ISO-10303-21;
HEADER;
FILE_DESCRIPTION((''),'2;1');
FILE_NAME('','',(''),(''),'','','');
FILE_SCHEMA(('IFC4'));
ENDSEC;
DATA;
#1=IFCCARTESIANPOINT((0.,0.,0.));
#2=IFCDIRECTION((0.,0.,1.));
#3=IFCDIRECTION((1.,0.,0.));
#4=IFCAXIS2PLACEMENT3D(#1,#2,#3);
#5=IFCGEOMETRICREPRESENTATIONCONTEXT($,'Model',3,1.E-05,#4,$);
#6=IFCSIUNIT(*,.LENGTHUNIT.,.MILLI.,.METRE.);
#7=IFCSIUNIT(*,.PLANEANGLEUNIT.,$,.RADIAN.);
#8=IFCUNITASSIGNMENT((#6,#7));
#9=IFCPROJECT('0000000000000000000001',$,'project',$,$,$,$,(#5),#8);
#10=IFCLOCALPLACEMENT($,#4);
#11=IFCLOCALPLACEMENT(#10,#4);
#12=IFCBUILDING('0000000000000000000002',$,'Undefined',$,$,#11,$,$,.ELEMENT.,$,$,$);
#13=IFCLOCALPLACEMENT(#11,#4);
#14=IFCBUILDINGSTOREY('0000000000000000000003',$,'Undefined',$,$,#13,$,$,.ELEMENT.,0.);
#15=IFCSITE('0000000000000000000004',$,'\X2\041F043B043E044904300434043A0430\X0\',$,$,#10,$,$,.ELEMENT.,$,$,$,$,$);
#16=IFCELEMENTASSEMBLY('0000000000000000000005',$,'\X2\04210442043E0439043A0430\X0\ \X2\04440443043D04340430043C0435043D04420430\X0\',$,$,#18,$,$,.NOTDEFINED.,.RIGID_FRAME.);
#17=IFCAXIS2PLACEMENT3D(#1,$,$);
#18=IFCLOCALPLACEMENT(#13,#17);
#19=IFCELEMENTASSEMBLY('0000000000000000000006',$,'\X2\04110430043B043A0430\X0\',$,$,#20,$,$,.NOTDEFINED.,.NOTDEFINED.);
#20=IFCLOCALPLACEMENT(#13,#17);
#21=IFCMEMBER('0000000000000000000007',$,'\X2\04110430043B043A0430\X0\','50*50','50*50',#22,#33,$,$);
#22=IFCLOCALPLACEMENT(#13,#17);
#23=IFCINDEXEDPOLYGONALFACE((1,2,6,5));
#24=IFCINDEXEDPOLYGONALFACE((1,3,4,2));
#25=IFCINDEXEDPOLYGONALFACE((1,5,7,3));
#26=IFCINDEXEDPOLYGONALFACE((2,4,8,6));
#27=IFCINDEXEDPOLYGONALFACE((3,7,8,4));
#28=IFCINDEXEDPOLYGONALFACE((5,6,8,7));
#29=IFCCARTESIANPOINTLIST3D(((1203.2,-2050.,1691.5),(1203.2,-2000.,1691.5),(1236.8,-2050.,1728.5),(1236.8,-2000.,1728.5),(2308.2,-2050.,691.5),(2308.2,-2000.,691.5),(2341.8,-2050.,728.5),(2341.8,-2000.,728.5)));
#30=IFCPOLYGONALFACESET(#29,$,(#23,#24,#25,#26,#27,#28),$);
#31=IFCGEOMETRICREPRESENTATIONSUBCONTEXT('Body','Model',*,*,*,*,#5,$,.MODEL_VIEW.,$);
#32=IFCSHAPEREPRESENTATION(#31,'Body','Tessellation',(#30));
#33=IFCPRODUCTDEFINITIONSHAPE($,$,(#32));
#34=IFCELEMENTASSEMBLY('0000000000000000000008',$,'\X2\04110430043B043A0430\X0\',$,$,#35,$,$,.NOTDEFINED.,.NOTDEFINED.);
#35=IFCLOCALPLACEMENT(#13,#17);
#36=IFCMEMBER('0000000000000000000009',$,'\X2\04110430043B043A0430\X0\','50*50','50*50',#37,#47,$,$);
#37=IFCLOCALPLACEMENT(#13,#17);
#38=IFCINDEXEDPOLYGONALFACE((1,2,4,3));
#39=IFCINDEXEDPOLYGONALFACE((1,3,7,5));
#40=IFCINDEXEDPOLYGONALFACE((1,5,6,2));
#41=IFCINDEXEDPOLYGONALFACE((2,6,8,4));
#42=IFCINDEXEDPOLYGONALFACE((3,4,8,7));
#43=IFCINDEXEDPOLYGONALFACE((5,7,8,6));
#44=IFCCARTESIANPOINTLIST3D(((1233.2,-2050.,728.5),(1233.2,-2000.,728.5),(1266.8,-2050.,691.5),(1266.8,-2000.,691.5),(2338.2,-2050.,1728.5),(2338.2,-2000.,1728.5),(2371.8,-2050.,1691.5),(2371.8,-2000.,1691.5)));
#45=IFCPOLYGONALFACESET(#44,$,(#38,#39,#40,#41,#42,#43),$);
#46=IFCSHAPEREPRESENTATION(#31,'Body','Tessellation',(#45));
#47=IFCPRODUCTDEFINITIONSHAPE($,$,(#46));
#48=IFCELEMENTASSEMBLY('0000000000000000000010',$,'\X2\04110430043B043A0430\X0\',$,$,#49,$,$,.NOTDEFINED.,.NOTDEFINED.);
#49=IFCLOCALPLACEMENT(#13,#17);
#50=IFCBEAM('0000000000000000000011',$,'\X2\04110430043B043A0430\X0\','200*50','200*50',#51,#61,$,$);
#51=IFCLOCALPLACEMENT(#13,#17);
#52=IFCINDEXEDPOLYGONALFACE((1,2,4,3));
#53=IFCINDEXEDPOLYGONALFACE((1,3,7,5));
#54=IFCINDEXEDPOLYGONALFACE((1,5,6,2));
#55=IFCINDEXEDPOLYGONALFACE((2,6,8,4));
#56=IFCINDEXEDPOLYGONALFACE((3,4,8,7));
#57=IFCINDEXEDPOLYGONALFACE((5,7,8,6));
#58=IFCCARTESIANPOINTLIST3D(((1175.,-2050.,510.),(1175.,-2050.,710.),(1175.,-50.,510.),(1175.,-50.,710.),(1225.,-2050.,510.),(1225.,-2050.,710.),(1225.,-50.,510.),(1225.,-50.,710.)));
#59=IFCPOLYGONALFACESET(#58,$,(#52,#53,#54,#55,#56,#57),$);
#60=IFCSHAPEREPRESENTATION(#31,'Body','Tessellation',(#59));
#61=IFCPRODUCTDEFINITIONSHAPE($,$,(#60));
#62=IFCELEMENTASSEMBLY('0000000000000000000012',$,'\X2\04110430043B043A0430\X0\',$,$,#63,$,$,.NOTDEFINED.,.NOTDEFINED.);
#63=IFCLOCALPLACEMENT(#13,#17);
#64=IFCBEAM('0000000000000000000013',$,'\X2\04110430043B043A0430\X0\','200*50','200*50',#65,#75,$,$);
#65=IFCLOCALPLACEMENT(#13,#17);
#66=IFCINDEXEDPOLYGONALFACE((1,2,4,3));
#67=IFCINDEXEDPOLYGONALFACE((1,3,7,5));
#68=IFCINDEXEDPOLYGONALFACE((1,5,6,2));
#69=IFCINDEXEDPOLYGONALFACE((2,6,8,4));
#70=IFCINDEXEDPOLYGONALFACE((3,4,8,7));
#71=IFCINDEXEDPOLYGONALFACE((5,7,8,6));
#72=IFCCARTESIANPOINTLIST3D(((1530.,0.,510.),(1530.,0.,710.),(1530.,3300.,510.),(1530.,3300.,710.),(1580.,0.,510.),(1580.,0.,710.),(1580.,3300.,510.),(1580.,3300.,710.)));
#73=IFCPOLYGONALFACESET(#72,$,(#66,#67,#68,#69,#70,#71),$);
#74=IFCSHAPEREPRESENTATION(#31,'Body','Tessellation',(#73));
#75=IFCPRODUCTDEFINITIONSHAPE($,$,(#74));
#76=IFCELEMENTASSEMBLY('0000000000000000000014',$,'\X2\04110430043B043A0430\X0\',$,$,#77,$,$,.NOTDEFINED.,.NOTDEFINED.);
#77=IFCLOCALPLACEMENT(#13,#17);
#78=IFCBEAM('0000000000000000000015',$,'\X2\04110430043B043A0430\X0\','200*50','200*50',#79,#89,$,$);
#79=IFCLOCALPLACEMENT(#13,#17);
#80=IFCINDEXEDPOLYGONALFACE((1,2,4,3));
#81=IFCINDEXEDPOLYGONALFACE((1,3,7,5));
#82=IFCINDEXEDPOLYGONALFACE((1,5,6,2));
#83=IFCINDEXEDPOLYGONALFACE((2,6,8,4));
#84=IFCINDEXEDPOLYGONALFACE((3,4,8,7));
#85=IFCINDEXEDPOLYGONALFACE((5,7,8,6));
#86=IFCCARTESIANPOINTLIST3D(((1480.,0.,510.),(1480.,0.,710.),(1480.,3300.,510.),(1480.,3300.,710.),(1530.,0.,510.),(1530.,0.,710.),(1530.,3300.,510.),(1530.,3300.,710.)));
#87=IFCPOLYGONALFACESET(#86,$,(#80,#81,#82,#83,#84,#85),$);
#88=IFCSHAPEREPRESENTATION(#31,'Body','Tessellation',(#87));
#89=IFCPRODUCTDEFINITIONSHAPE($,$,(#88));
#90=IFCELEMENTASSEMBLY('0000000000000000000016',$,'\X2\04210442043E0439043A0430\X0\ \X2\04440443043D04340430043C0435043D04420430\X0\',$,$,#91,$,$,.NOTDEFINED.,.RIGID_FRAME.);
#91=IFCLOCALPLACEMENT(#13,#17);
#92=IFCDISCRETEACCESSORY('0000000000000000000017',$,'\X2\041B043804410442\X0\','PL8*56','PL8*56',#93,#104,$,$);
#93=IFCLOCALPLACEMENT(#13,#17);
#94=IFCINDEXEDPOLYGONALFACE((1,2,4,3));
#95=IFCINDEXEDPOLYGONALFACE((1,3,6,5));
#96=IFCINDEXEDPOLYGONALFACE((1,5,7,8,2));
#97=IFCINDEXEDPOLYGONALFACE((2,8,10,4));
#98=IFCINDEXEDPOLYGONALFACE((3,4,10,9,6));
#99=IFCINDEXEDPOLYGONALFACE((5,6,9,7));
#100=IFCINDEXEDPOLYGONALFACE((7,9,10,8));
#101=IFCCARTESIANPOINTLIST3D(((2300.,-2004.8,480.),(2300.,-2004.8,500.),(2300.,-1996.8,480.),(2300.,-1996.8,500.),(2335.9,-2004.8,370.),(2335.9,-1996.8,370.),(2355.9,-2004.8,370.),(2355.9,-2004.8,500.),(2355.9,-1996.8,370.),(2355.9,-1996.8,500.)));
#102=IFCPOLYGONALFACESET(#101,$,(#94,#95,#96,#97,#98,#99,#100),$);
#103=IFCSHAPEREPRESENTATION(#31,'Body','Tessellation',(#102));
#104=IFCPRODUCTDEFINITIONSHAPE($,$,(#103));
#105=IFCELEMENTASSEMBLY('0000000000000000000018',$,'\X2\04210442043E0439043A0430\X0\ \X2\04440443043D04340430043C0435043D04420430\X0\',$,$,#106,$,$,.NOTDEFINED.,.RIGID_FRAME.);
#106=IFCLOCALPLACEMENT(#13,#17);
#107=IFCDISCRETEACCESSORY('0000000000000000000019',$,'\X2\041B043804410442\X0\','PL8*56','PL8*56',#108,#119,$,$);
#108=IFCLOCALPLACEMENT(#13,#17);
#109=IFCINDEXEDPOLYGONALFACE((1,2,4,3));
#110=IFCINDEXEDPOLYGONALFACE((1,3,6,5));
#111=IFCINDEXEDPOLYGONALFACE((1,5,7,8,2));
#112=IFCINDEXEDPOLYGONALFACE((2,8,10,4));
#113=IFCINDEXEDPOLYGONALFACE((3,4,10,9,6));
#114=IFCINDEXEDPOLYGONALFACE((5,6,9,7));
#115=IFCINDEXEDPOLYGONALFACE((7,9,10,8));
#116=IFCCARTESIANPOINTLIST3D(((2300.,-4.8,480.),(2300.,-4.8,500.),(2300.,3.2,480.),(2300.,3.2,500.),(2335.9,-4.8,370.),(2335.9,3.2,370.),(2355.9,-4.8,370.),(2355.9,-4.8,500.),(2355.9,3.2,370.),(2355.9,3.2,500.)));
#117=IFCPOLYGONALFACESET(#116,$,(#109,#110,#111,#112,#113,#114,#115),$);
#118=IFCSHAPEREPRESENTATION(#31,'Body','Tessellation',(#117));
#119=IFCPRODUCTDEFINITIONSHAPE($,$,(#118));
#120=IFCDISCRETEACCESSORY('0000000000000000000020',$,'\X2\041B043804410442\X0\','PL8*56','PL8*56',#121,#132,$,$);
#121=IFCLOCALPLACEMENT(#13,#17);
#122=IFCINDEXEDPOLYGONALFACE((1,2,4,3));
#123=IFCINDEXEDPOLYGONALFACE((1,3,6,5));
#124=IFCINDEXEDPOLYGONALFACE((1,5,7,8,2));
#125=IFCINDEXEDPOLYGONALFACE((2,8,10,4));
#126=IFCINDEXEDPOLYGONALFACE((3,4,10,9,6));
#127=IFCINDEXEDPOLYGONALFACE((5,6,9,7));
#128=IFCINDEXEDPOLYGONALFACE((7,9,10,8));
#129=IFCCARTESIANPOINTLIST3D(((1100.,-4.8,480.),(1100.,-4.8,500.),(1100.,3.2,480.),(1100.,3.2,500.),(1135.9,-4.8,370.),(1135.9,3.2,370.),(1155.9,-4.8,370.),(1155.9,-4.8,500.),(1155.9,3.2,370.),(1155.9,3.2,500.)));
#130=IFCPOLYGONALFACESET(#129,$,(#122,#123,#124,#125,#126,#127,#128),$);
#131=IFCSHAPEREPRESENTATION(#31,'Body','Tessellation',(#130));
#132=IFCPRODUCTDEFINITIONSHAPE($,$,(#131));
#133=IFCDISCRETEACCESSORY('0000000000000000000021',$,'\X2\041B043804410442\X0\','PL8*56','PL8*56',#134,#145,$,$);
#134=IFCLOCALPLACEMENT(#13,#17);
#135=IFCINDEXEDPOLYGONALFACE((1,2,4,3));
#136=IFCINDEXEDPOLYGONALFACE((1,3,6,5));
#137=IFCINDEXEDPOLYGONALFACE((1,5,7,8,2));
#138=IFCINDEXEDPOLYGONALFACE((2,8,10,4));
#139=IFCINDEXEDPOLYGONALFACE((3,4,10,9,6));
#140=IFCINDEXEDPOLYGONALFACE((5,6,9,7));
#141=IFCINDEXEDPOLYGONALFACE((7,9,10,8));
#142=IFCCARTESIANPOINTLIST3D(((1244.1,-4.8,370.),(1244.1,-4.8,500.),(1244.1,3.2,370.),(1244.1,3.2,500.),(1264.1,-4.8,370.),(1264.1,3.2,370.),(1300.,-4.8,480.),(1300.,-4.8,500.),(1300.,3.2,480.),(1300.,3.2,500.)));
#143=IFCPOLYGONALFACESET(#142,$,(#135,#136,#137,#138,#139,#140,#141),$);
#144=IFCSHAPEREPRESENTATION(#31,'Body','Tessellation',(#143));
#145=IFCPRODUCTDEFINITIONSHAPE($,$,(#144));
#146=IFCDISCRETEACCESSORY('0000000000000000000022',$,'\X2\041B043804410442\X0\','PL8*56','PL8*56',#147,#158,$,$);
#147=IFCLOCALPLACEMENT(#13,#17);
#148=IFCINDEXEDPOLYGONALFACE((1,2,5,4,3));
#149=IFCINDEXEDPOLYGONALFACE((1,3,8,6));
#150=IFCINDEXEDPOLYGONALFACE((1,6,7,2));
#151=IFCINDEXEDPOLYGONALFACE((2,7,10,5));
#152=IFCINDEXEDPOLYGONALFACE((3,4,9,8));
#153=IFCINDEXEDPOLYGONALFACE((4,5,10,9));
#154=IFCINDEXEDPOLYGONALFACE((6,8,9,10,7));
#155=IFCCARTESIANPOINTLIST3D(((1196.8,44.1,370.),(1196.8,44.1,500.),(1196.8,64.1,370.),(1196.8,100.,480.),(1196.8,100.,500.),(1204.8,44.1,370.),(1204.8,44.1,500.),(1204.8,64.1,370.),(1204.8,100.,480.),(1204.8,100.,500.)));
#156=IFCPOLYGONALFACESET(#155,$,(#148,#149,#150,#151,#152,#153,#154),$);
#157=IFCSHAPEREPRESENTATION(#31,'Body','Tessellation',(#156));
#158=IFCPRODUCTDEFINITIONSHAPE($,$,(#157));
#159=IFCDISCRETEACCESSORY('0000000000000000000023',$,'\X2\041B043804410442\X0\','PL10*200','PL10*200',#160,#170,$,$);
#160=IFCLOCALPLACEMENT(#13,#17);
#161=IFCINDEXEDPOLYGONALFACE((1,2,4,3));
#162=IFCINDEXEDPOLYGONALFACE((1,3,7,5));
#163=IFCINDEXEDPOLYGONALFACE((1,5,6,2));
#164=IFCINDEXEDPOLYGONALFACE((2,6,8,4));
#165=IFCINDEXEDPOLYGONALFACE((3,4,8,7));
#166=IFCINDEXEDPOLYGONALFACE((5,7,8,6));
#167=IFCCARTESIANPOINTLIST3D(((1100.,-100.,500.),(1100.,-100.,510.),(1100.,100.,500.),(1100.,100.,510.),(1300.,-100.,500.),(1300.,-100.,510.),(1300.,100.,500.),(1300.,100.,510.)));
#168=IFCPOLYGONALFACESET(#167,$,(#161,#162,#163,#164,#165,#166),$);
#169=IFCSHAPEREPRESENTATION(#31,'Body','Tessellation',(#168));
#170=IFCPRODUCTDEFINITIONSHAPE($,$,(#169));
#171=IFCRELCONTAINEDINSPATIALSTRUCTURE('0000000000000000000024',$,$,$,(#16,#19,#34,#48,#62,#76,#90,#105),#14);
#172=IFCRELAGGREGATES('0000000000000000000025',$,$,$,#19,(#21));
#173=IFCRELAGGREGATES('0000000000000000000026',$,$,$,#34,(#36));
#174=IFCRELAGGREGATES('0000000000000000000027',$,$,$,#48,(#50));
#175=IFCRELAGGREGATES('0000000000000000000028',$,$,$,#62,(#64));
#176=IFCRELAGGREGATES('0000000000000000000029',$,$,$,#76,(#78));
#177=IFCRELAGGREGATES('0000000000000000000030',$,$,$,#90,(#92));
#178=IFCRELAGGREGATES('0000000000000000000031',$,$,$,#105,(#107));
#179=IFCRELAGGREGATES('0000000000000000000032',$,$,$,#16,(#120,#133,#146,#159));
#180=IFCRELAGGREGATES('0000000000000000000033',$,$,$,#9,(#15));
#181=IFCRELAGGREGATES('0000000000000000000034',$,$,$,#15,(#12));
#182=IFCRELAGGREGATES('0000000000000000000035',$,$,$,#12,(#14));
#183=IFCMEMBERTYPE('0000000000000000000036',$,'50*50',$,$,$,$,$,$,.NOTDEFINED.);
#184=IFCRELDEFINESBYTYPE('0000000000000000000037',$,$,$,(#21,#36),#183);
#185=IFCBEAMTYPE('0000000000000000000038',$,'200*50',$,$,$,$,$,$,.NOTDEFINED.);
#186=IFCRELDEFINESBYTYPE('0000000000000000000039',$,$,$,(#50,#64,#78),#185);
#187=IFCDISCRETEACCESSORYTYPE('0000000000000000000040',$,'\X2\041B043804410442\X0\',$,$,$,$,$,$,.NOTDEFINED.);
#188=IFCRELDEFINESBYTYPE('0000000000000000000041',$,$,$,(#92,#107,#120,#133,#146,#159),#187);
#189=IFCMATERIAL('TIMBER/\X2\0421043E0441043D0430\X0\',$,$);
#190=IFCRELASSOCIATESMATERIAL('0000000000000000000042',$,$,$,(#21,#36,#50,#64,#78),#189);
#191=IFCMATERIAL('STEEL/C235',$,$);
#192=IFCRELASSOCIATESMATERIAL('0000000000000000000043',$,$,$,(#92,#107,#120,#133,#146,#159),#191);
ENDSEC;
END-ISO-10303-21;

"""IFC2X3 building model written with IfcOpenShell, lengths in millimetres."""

from ifc_helpers import new_model, si_unit, frame, origin_with_axes, origin_2d_with_axis, place, context, subcontext, project, spatial, polyline, rectangle, outline, extrude, material, type_object, element, aggregate, save


model = new_model("IFC2X3")

# Units and contexts
model_context = context("Model", 3, precision=1e-05, world=origin_with_axes())
body_context = subcontext(model_context, "Body", "Model", "MODEL_VIEW")
ifc_project = project(units=[si_unit("LENGTHUNIT", "METRE", prefix="MILLI"), si_unit("PLANEANGLEUNIT", "RADIAN")], contexts=[model_context])

# Site, building, storey
site_placement = place(None, origin_with_axes())
site = spatial("IfcSite", under=ifc_project, at=site_placement, Name="Площадка", CompositionType="ELEMENT")
building_placement = place(site_placement, origin_with_axes())
building = spatial("IfcBuilding", under=site, at=building_placement, Name="Undefined", CompositionType="ELEMENT")
storey_placement = place(building_placement, origin_with_axes())
storey = spatial("IfcBuildingStorey", under=building, at=storey_placement, Name="Undefined", CompositionType="ELEMENT", Elevation=0.0)

# Element assembly
ifc_material_1 = material(Name="TIMBER/Сосна")
assembly_1_placement = place(storey_placement, origin_with_axes())
assembly_1 = element("IfcElementAssembly", 1, at=assembly_1_placement, inside=storey, Name="Стойка фундамента", AssemblyPlace="NOTDEFINED", PredefinedType="RIGID_FRAME")
ifc_material_2 = material(Name="STEEL/C235")

# Element assemblies, members
assembly_2_placement = place(storey_placement, origin_with_axes())
assembly_2 = element("IfcElementAssembly", 2, at=assembly_2_placement, inside=storey, Name="Балка", AssemblyPlace="NOTDEFINED", PredefinedType="NOTDEFINED")
member_type = type_object("IfcMemberType", Name="50*50", PredefinedType="NOTDEFINED")
member_1_placement = place(assembly_2_placement, frame((2325.0, -2025.0, 710.0), z_axis=(0.0, 1.0, 0.0), x_axis=(-0.741456, 0.0, 0.671001)))
member_1 = element("IfcMember", 3, at=member_1_placement, type_object=member_type, material=ifc_material_1, Name="Балка", Description="50*50", ObjectType="50*50", context=body_context, shape_type="SweptSolid", body=[
    extrude(rectangle(XDim=50.0, YDim=50.0, at=origin_2d_with_axis()), frame((1490.3, 0.0, 0.0), z_axis=(-1.0, 0.0, 0.0), x_axis=(0.0, -1.0, 0.0)), (0.0, 0.0, 1.0), 1490.3),
])
aggregate(assembly_2, [member_1])
assembly_3_placement = place(storey_placement, origin_with_axes())
assembly_3 = element("IfcElementAssembly", 4, at=assembly_3_placement, inside=storey, Name="Балка", AssemblyPlace="NOTDEFINED", PredefinedType="NOTDEFINED")
member_2_placement = place(assembly_3_placement, frame((1250.0, -2025.0, 710.0), z_axis=(0.0, 1.0, 0.0), x_axis=(0.741456, 0.0, 0.671001)))
member_2 = element("IfcMember", 5, at=member_2_placement, type_object=member_type, material=ifc_material_1, Name="Балка", Description="50*50", ObjectType="50*50", context=body_context, shape_type="SweptSolid", body=[
    extrude(rectangle(XDim=50.0, YDim=50.0, at=origin_2d_with_axis()), frame((1490.3, 0.0, 0.0), z_axis=(-1.0, 0.0, 0.0), x_axis=(0.0, -1.0, 0.0)), (0.0, 0.0, 1.0), 1490.3),
])
aggregate(assembly_3, [member_2])

# Element assemblies, beams
assembly_4_placement = place(storey_placement, origin_with_axes())
assembly_4 = element("IfcElementAssembly", 6, at=assembly_4_placement, inside=storey, Name="Балка", AssemblyPlace="NOTDEFINED", PredefinedType="NOTDEFINED")
beam_type_1 = type_object("IfcBeamType", Name="200*50", PredefinedType="NOTDEFINED")
beam_1_placement = place(assembly_4_placement, frame((1200.0, -2050.0, 610.0), z_axis=(0.0, 0.0, -1.0), x_axis=(0.0, 1.0, 0.0)))
beam_1 = element("IfcBeam", 7, at=beam_1_placement, type_object=beam_type_1, material=ifc_material_1, Name="Балка", Description="200*50", ObjectType="200*50", context=body_context, shape_type="SweptSolid", body=[
    extrude(rectangle(XDim=50.0, YDim=200.0, at=origin_2d_with_axis()), frame((2000.0, 0.0, 0.0), z_axis=(-1.0, 0.0, 0.0), x_axis=(0.0, -1.0, 0.0)), (0.0, 0.0, 1.0), 2000.0),
])
aggregate(assembly_4, [beam_1])
assembly_5_placement = place(storey_placement, origin_with_axes())
assembly_5 = element("IfcElementAssembly", 8, at=assembly_5_placement, inside=storey, Name="Балка", AssemblyPlace="NOTDEFINED", PredefinedType="NOTDEFINED")
beam_2_placement = place(assembly_5_placement, frame((1555.0, 0.0, 610.0), z_axis=(0.0, 0.0, -1.0), x_axis=(0.0, 1.0, 0.0)))
beam_2 = element("IfcBeam", 9, at=beam_2_placement, type_object=beam_type_1, material=ifc_material_1, Name="Балка", Description="200*50", ObjectType="200*50", context=body_context, shape_type="SweptSolid", body=[
    extrude(rectangle(XDim=50.0, YDim=200.0, at=origin_2d_with_axis()), frame((3300.0, 0.0, 0.0), z_axis=(-1.0, 0.0, 0.0), x_axis=(0.0, -1.0, 0.0)), (0.0, 0.0, 1.0), 3300.0),
])
aggregate(assembly_5, [beam_2])
assembly_6_placement = place(storey_placement, origin_with_axes())
assembly_6 = element("IfcElementAssembly", 10, at=assembly_6_placement, inside=storey, Name="Балка", AssemblyPlace="NOTDEFINED", PredefinedType="NOTDEFINED")
beam_3_placement = place(assembly_6_placement, frame((1505.0, 0.0, 610.0), z_axis=(0.0, 0.0, -1.0), x_axis=(0.0, 1.0, 0.0)))
beam_3 = element("IfcBeam", 11, at=beam_3_placement, type_object=beam_type_1, material=ifc_material_1, Name="Балка", Description="200*50", ObjectType="200*50", context=body_context, shape_type="SweptSolid", body=[
    extrude(rectangle(XDim=50.0, YDim=200.0, at=origin_2d_with_axis()), frame((3300.0, 0.0, 0.0), z_axis=(-1.0, 0.0, 0.0), x_axis=(0.0, -1.0, 0.0)), (0.0, 0.0, 1.0), 3300.0),
])
aggregate(assembly_6, [beam_3])

# Element assemblies, discrete accessories
assembly_7_placement = place(storey_placement, origin_with_axes())
assembly_7 = element("IfcElementAssembly", 12, at=assembly_7_placement, inside=storey, Name="Стойка фундамента", AssemblyPlace="NOTDEFINED", PredefinedType="RIGID_FRAME")
discrete_accessory_type = type_object("IfcDiscreteAccessoryType", Name="Лист")
discrete_accessory_1_placement = place(assembly_7_placement, frame((2355.9, -2000.8, 500.0), z_axis=(0.0, -1.0, 0.0), x_axis=(-1.0, 0.0, 0.0)))
discrete_accessory_1 = element("IfcDiscreteAccessory", 13, at=discrete_accessory_1_placement, type_object=discrete_accessory_type, material=ifc_material_2, Name="Лист", Description="PL8*56", ObjectType="PL8*56", context=body_context, shape_type="SweptSolid", body=[
    extrude(outline(polyline([(0.0, 0.0), (55.9, 0.0), (55.9, 20.0), (20.0, 130.0), (0.0, 130.0), (0.0, 0.0)])), frame((0.0, 0.0, -4.0), z_axis=(0.0, 0.0, 1.0), x_axis=(1.0, 0.0, 0.0)), (0.0, 0.0, 1.0), 8.0),
])
aggregate(assembly_7, [discrete_accessory_1])
assembly_8_placement = place(storey_placement, origin_with_axes())
assembly_8 = element("IfcElementAssembly", 14, at=assembly_8_placement, inside=storey, Name="Стойка фундамента", AssemblyPlace="NOTDEFINED", PredefinedType="RIGID_FRAME")
discrete_accessory_2_placement = place(assembly_8_placement, frame((2355.9, -0.8, 500.0), z_axis=(0.0, -1.0, 0.0), x_axis=(-1.0, 0.0, 0.0)))
discrete_accessory_2 = element("IfcDiscreteAccessory", 15, at=discrete_accessory_2_placement, type_object=discrete_accessory_type, material=ifc_material_2, Name="Лист", Description="PL8*56", ObjectType="PL8*56", context=body_context, shape_type="SweptSolid", body=[
    extrude(outline(polyline([(0.0, 0.0), (55.9, 0.0), (55.9, 20.0), (20.0, 130.0), (0.0, 130.0), (0.0, 0.0)])), frame((0.0, 0.0, -4.0), z_axis=(0.0, 0.0, 1.0), x_axis=(1.0, 0.0, 0.0)), (0.0, 0.0, 1.0), 8.0),
])
aggregate(assembly_8, [discrete_accessory_2])

# Discrete accessories
discrete_accessory_3_placement = place(assembly_1_placement, frame((1155.9, -0.8, 500.0), z_axis=(0.0, -1.0, 0.0), x_axis=(-1.0, 0.0, 0.0)))
discrete_accessory_3 = element("IfcDiscreteAccessory", 16, at=discrete_accessory_3_placement, type_object=discrete_accessory_type, material=ifc_material_2, Name="Лист", Description="PL8*56", ObjectType="PL8*56", context=body_context, shape_type="SweptSolid", body=[
    extrude(outline(polyline([(0.0, 0.0), (55.9, 0.0), (55.9, 20.0), (20.0, 130.0), (0.0, 130.0), (0.0, 0.0)])), frame((0.0, 0.0, -4.0), z_axis=(0.0, 0.0, 1.0), x_axis=(1.0, 0.0, 0.0)), (0.0, 0.0, 1.0), 8.0),
])
discrete_accessory_4_placement = place(assembly_1_placement, frame((1244.1, -0.8, 500.0), z_axis=(0.0, 1.0, 0.0), x_axis=(1.0, 0.0, 0.0)))
discrete_accessory_4 = element("IfcDiscreteAccessory", 17, at=discrete_accessory_4_placement, type_object=discrete_accessory_type, material=ifc_material_2, Name="Лист", Description="PL8*56", ObjectType="PL8*56", context=body_context, shape_type="SweptSolid", body=[
    extrude(outline(polyline([(0.0, 0.0), (55.9, 0.0), (55.9, 20.0), (20.0, 130.0), (0.0, 130.0), (0.0, 0.0)])), frame((0.0, 0.0, -4.0), z_axis=(0.0, 0.0, 1.0), x_axis=(1.0, 0.0, 0.0)), (0.0, 0.0, 1.0), 8.0),
])
discrete_accessory_5_placement = place(assembly_1_placement, frame((1200.8, 44.1, 500.0), z_axis=(-1.0, 0.0, 0.0), x_axis=(0.0, 1.0, 0.0)))
discrete_accessory_5 = element("IfcDiscreteAccessory", 18, at=discrete_accessory_5_placement, type_object=discrete_accessory_type, material=ifc_material_2, Name="Лист", Description="PL8*56", ObjectType="PL8*56", context=body_context, shape_type="SweptSolid", body=[
    extrude(outline(polyline([(0.0, 0.0), (55.9, 0.0), (55.9, 20.0), (20.0, 130.0), (0.0, 130.0), (0.0, 0.0)])), frame((0.0, 0.0, -4.0), z_axis=(0.0, 0.0, 1.0), x_axis=(1.0, 0.0, 0.0)), (0.0, 0.0, 1.0), 8.0),
])
discrete_accessory_6_placement = place(assembly_1_placement, frame((1300.0, -100.0, 505.0), z_axis=(0.0, 0.0, -1.0), x_axis=(-1.0, 0.0, 0.0)))
discrete_accessory_6 = element("IfcDiscreteAccessory", 19, at=discrete_accessory_6_placement, type_object=discrete_accessory_type, material=ifc_material_2, Name="Лист", Description="PL10*200", ObjectType="PL10*200", context=body_context, shape_type="SweptSolid", body=[
    extrude(outline(polyline([(0.0, 0.0), (200.0, 0.0), (200.0, 200.0), (0.0, 200.0), (0.0, 0.0)])), frame((0.0, 0.0, -5.0), z_axis=(0.0, 0.0, 1.0), x_axis=(1.0, 0.0, 0.0)), (0.0, 0.0, 1.0), 10.0),
])
aggregate(assembly_1, [discrete_accessory_3, discrete_accessory_4, discrete_accessory_5, discrete_accessory_6])

save(model, "model.ifc")
